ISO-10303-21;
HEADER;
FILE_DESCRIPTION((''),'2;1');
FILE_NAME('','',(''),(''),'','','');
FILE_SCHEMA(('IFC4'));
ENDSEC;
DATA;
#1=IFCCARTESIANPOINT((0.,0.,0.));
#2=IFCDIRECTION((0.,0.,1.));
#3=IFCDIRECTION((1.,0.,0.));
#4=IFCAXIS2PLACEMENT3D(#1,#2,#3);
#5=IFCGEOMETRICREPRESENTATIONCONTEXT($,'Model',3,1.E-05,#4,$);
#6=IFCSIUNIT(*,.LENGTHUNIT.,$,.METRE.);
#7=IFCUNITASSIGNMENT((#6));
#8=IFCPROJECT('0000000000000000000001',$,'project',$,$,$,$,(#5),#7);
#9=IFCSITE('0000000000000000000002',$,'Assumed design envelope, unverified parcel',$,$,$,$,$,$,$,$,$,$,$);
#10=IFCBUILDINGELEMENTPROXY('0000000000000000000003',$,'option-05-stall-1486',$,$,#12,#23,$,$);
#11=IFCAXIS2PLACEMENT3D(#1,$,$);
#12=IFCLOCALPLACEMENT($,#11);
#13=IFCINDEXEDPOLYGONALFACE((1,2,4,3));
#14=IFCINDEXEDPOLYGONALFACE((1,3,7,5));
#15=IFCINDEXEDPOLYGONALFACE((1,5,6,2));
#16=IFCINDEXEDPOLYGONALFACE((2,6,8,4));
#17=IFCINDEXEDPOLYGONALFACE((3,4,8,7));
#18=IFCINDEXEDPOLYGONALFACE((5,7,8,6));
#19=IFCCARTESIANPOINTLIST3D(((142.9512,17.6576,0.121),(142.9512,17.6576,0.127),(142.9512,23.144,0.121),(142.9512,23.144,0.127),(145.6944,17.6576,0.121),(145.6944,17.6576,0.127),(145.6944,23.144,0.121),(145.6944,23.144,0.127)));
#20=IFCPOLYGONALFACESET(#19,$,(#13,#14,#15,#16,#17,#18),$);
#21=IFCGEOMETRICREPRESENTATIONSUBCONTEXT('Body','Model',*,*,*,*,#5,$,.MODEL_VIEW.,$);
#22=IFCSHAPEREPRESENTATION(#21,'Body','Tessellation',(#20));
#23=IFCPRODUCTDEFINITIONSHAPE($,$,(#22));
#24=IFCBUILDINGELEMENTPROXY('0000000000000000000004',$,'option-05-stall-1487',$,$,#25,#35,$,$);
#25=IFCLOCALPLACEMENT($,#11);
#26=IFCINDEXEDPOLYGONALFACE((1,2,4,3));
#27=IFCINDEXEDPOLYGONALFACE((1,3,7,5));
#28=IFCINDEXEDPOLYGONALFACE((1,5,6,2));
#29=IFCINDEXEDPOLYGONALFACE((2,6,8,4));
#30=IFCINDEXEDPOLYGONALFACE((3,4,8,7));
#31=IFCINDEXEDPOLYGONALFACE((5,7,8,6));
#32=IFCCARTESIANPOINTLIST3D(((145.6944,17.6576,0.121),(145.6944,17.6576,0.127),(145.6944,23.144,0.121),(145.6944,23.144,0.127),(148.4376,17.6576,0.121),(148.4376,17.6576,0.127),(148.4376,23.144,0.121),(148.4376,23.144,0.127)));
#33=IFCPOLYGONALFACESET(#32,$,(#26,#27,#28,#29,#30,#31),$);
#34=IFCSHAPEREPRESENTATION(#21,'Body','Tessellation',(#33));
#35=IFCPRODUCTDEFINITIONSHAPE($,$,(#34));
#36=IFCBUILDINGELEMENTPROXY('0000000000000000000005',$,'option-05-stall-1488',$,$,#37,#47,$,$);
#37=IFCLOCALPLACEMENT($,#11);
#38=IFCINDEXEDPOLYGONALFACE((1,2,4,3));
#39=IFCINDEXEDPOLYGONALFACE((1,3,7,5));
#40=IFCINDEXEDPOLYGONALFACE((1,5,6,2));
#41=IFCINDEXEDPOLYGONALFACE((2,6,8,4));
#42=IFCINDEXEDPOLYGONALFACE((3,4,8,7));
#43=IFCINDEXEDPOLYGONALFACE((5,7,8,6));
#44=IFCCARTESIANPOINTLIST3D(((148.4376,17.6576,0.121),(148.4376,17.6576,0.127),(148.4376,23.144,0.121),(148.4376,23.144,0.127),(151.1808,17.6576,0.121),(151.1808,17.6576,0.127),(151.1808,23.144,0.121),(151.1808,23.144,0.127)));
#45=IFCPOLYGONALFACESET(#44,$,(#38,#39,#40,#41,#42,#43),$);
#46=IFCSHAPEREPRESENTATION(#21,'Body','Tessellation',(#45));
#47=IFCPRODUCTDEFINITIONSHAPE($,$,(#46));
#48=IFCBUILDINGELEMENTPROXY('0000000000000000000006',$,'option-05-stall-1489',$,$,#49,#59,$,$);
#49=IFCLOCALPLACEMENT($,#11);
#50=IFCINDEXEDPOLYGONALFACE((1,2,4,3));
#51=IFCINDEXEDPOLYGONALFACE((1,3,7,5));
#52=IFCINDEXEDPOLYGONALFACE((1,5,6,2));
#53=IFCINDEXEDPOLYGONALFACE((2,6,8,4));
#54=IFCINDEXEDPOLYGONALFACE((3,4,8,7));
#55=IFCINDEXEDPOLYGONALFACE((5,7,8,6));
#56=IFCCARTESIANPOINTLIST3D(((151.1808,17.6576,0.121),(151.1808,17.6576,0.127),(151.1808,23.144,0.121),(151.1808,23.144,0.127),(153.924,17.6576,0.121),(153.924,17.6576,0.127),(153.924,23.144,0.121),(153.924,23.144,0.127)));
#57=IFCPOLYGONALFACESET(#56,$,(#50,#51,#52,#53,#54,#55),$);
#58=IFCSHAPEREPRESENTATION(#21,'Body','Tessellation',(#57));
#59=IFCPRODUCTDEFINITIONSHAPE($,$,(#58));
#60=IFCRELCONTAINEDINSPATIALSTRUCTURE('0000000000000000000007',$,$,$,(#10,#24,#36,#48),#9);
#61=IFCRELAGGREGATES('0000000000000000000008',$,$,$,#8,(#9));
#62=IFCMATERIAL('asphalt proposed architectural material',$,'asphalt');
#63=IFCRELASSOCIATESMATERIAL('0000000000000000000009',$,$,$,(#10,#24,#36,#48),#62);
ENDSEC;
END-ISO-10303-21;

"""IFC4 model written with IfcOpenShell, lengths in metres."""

from ifc_helpers import new_model, si_unit, frame, origin_with_axes, place, context, subcontext, project, spatial, rectangle, extrude, material, element, save


model = new_model("IFC4")

# Units and contexts
model_context = context("Model", 3, precision=1e-05, world=origin_with_axes())
body_context = subcontext(model_context, "Body", "Model", "MODEL_VIEW")
ifc_project = project(units=[si_unit("LENGTHUNIT", "METRE")], contexts=[model_context])

# Site
site = spatial("IfcSite", under=ifc_project, Name="Assumed design envelope, unverified parcel")

# Building element proxies
ifc_material = material(Name="asphalt proposed architectural material", Category="asphalt")
for number, where, z_axis, x_axis, name in (
    (1, (144.3228, 20.4008, 0.121), (0.0, 0.0, 1.0), (1.0, 0.0, 0.0), "option-05-stall-1486"),
    (2, (147.066, 20.4008, 0.121), (0.0, 0.0, 1.0), (1.0, 0.0, 0.0), "option-05-stall-1487"),
    (3, (149.8092, 20.4008, 0.121), (0.0, 0.0, 1.0), (1.0, 0.0, 0.0), "option-05-stall-1488"),
    (4, (152.5524, 20.4008, 0.121), (0.0, 0.0, 1.0), (1.0, 0.0, 0.0), "option-05-stall-1489"),
):
    element("IfcBuildingElementProxy", number, at=place(None, frame(where, z_axis=z_axis, x_axis=x_axis)), inside=site, material=ifc_material, Name=name, context=body_context, shape_type="SweptSolid", body=[
        extrude(rectangle(XDim=2.7432, YDim=5.4864), origin_with_axes(), (0.0, 0.0, 1.0), 0.006),
    ])

save(model, "model.ifc")
